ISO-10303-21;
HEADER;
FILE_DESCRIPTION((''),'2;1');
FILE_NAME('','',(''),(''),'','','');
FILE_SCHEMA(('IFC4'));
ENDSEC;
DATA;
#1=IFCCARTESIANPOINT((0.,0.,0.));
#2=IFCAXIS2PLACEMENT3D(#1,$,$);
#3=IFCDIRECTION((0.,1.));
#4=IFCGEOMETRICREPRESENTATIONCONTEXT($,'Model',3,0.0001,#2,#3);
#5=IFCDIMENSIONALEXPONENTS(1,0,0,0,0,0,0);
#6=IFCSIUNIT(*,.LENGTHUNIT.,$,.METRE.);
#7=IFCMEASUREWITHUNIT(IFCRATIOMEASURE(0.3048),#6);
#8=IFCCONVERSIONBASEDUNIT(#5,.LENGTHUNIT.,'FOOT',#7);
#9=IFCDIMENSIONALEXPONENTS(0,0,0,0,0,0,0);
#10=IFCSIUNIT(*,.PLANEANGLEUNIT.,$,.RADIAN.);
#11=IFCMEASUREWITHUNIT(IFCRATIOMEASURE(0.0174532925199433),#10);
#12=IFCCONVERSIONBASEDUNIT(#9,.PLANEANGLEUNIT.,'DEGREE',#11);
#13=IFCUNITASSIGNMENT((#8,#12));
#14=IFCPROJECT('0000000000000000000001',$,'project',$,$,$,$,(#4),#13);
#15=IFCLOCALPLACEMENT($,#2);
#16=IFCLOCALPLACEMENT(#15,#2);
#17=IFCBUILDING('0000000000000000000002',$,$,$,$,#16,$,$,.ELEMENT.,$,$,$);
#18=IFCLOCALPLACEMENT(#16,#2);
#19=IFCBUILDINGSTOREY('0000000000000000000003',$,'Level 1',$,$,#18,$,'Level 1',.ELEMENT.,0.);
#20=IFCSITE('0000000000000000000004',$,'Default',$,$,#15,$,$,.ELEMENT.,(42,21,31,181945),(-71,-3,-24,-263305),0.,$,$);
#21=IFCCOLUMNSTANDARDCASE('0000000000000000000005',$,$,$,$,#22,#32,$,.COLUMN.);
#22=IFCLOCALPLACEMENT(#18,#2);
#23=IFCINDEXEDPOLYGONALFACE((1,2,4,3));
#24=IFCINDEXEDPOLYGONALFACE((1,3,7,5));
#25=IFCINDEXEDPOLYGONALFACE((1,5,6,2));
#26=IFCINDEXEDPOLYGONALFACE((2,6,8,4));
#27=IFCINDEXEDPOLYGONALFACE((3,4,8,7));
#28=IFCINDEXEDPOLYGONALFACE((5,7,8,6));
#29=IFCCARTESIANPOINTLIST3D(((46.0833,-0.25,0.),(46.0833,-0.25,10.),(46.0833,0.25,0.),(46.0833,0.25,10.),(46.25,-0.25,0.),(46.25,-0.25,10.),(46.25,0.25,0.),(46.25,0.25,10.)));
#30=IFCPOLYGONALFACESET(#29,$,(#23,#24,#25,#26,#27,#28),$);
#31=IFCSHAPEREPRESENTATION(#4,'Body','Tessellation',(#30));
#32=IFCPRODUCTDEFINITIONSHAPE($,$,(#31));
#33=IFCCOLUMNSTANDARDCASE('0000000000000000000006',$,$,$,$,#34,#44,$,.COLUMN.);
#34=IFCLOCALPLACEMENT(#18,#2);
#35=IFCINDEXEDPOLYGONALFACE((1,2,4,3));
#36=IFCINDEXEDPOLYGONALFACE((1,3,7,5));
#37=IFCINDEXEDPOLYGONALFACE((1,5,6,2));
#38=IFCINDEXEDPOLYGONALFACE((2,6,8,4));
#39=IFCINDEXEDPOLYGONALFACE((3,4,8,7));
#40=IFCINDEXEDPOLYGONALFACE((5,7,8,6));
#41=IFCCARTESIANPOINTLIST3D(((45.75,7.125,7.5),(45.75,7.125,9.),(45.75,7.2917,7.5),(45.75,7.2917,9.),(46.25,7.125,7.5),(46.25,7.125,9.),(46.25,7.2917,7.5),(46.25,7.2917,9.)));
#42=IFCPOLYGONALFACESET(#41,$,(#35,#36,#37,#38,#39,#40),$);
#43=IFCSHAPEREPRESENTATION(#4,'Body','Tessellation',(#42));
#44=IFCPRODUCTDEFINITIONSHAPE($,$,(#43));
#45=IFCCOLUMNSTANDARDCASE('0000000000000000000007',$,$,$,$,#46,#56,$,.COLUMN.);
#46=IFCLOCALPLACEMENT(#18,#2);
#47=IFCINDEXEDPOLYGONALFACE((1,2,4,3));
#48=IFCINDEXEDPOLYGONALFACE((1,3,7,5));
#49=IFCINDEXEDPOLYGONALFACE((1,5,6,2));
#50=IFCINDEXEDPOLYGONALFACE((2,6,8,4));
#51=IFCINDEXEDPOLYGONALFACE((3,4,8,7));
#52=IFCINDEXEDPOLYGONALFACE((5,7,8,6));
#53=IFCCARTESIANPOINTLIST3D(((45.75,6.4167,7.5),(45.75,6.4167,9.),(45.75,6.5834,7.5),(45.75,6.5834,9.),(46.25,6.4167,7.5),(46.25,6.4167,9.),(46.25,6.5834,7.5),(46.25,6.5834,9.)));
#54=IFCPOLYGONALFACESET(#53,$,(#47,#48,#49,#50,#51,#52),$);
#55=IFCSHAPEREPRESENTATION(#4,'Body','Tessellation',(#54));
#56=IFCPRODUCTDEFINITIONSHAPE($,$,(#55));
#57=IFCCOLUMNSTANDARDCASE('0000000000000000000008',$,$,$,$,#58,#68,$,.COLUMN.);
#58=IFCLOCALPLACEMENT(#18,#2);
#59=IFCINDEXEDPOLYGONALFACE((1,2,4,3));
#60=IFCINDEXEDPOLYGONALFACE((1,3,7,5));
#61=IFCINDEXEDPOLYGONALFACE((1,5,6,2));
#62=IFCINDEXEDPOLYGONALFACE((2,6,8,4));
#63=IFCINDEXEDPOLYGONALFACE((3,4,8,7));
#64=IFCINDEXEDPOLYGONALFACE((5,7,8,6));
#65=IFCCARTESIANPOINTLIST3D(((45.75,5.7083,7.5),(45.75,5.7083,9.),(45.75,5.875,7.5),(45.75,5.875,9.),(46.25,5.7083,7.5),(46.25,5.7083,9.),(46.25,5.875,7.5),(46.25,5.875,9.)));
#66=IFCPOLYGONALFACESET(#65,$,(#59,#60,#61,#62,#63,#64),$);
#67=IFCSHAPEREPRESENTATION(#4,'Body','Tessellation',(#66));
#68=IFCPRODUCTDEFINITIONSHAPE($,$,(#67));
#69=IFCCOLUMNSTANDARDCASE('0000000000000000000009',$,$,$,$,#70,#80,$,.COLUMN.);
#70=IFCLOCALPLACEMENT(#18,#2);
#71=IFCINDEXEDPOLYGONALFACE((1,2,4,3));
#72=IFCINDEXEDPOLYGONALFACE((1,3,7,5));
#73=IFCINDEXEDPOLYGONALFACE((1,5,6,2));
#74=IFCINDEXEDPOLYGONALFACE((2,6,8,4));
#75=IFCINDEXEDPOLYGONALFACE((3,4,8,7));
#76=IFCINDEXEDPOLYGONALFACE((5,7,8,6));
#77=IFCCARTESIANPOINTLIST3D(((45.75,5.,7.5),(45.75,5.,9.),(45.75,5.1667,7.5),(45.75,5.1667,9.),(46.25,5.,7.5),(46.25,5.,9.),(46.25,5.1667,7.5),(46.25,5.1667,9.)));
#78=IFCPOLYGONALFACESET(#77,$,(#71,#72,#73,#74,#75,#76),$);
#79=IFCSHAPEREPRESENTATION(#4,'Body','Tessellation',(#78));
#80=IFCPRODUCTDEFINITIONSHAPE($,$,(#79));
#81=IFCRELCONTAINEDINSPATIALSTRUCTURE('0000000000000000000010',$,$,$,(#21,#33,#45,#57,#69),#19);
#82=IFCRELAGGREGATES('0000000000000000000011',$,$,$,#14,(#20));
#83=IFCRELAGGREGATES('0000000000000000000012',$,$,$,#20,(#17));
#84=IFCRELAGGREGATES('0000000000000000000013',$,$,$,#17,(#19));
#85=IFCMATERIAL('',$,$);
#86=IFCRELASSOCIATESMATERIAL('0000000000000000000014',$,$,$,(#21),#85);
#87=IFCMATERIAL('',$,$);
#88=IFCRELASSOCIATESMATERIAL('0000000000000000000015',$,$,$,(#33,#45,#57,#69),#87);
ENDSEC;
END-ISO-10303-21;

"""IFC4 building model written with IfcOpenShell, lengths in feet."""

from ifc_helpers import new_model, entity, si_unit, converted_unit, direction, frame, origin, place, context, project, spatial, rectangle, extrude, material, element, save


model = new_model("IFC4")

# Units and contexts
model_context = context("Model", 3, precision=0.0001, world=origin(), true_north=direction((0.0, 1.0)))
ifc_project = project(units=[converted_unit("LENGTHUNIT", "FOOT", entity("IfcRatioMeasure", 0.3048), si_unit("LENGTHUNIT", "METRE"), dimensions=[1, 0, 0, 0, 0, 0, 0]), converted_unit("PLANEANGLEUNIT", "DEGREE", entity("IfcRatioMeasure", 0.0174532925199433), si_unit("PLANEANGLEUNIT", "RADIAN"), dimensions=[0, 0, 0, 0, 0, 0, 0])], contexts=[model_context])

# Site, building, storey
site_placement = place(None, origin())
site = spatial("IfcSite", under=ifc_project, at=site_placement, Name="Default", CompositionType="ELEMENT", RefLatitude=(42, 21, 31, 181945), RefLongitude=(-71, -3, -24, -263305), RefElevation=0.0)
building_placement = place(site_placement, origin())
building = spatial("IfcBuilding", under=site, at=building_placement, CompositionType="ELEMENT")
storey_placement = place(building_placement, origin())
storey = spatial("IfcBuildingStorey", under=building, at=storey_placement, Name="Level 1", LongName="Level 1", CompositionType="ELEMENT", Elevation=0.0)

# Columns
ifc_material_1 = material(Name="")
wall_placement = place(storey_placement, frame((46.25, 0.0, 0.0), z_axis=(0.0, 0.0, 1.0), x_axis=(-1.0, 0.0, 0.0)))
column_placement = place(wall_placement, frame((0.0833, 0.0, 0.0), z_axis=(0.0, 0.0, 1.0), x_axis=(1.0, 0.0, 0.0)))
element("IfcColumnStandardCase", 1, at=column_placement, inside=storey, material=ifc_material_1, PredefinedType="COLUMN", context=model_context, shape_type="SweptSolid", body=[
    extrude(rectangle(XDim=0.1667, YDim=0.5), origin(), (0.0, 0.0, 1.0), 10.0),
])
ifc_material_2 = material(Name="")
placement = place(storey_placement, frame((46.0, 46.25, 0.0), z_axis=(0.0, 0.0, 1.0), x_axis=(0.0, -1.0, 0.0)))
for number, where, z_axis, x_axis in (
    (2, (39.0417, 0.0, 7.5), (0.0, 0.0, 1.0), (1.0, 0.0, 0.0)),
    (3, (39.75, 0.0, 7.5), (0.0, 0.0, 1.0), (1.0, 0.0, 0.0)),
    (4, (40.4583, 0.0, 7.5), (0.0, 0.0, 1.0), (1.0, 0.0, 0.0)),
    (5, (41.1667, 0.0, 7.5), (0.0, 0.0, 1.0), (1.0, 0.0, 0.0)),
):
    element("IfcColumnStandardCase", number, at=place(placement, frame(where, z_axis=z_axis, x_axis=x_axis)), inside=storey, material=ifc_material_2, PredefinedType="COLUMN", context=model_context, shape_type="SweptSolid", body=[
        extrude(rectangle(XDim=0.1667, YDim=0.5), origin(), (0.0, 0.0, 1.0), 1.5),
    ])

save(model, "model.ifc")
